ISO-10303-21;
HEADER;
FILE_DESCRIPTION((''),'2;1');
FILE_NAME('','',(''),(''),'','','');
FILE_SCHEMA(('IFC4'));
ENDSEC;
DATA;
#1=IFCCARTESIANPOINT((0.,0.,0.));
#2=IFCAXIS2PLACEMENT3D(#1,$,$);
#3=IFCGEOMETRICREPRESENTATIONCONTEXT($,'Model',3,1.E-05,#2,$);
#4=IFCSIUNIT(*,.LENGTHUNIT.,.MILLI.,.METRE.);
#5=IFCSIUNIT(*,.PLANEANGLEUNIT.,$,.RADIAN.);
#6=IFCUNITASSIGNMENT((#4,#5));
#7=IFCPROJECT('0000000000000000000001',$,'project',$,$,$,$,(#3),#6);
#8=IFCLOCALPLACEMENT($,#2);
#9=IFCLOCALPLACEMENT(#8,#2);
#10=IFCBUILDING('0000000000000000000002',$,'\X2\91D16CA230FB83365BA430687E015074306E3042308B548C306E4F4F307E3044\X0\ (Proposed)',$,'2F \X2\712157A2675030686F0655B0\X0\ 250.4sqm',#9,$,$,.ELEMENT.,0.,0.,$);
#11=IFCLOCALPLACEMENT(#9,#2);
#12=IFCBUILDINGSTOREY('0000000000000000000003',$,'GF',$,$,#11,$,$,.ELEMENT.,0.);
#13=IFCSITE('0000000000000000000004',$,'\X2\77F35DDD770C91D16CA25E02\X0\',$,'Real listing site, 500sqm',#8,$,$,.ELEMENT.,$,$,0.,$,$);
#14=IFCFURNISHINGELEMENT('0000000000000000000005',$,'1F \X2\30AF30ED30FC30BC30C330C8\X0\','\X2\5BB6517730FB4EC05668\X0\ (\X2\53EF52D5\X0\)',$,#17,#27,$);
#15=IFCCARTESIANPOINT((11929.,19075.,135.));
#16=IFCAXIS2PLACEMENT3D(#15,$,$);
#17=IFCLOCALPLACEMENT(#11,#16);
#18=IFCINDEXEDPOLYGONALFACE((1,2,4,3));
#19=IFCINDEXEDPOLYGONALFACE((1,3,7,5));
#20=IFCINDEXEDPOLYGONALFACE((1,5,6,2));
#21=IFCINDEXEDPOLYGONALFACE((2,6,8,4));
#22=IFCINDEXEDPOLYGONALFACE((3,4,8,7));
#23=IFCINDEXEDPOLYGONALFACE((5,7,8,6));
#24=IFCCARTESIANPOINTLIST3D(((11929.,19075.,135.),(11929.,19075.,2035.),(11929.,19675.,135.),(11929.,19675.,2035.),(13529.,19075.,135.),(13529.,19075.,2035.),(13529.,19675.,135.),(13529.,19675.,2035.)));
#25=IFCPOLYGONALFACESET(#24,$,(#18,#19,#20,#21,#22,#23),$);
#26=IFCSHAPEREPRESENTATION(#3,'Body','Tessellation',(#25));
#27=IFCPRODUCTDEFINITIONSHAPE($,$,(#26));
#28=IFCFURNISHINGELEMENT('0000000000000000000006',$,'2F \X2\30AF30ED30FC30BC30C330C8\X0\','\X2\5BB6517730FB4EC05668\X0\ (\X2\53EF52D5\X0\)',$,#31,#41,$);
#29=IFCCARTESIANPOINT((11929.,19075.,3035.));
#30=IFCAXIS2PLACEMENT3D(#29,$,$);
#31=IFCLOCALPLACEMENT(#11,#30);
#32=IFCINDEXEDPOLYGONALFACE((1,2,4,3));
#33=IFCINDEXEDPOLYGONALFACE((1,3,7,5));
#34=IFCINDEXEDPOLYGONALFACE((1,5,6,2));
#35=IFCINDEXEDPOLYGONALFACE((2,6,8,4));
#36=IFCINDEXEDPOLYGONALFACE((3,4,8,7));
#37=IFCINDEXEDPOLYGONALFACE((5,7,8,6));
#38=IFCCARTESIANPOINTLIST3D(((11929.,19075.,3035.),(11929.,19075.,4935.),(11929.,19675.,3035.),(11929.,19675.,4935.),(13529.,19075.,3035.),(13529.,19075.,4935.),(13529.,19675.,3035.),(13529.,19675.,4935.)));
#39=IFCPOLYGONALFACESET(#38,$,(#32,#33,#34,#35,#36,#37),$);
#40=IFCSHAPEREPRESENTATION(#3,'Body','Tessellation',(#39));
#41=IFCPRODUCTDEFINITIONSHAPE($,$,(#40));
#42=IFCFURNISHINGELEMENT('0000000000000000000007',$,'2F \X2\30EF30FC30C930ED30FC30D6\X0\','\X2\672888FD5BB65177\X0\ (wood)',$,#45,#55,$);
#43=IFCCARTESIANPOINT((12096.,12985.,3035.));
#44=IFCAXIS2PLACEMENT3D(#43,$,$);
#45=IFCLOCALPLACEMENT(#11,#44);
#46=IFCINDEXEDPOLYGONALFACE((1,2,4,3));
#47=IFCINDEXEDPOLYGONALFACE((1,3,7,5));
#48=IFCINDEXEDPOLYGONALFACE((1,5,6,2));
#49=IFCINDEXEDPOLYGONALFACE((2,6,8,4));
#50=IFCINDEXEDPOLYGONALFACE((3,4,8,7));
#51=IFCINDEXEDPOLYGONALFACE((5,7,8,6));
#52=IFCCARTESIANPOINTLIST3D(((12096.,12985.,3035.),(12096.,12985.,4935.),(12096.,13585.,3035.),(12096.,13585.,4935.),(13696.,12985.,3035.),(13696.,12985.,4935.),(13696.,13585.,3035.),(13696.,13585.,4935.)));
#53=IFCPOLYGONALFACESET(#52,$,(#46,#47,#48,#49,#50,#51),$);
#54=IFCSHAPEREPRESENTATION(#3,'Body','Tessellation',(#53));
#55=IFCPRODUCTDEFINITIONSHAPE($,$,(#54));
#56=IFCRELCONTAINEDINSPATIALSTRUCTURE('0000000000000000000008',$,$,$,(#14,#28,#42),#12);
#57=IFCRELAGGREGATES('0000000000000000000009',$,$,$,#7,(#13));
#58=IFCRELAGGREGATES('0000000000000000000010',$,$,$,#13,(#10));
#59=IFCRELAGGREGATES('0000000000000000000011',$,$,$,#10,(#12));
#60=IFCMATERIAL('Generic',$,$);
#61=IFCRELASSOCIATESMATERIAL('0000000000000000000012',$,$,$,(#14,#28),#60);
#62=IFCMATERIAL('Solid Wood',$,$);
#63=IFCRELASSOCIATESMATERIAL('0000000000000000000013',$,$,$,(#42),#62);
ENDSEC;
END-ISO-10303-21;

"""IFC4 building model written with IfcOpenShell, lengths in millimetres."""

from ifc_helpers import new_model, si_unit, frame, frame_2d, origin, place, context, project, spatial, rectangle, extrude, material, element, save


model = new_model("IFC4")

# Units and contexts
model_context = context("Model", 3, precision=1e-05, world=origin())
ifc_project = project(units=[si_unit("LENGTHUNIT", "METRE", prefix="MILLI"), si_unit("PLANEANGLEUNIT", "RADIAN")], contexts=[model_context])

# Site, building, storey
site_placement = place(None, origin())
site = spatial("IfcSite", under=ifc_project, at=site_placement, Name="石川県金沢市", ObjectType="Real listing site, 500sqm", CompositionType="ELEMENT", RefElevation=0.0)
building_placement = place(site_placement, origin())
building = spatial("IfcBuilding", under=site, at=building_placement, Name="金沢・茶室と縁側のある和の住まい (Proposed)", ObjectType="2F 無垢材と漆喰 250.4sqm", CompositionType="ELEMENT", ElevationOfRefHeight=0.0, ElevationOfTerrain=0.0)
storey_placement = place(building_placement, origin())
storey = spatial("IfcBuildingStorey", under=building, at=storey_placement, Name="GF", CompositionType="ELEMENT", Elevation=0.0)

# Shared definitions
ifc_material_1 = material(Name="Solid Wood")

# Shared definitions
ifc_material_2 = material(Name="Generic")

# Furnishing elements
furnishing_1_placement = place(storey_placement, frame((11929.0, 19075.0, 135.0)))
element("IfcFurnishingElement", 1, at=furnishing_1_placement, inside=storey, material=ifc_material_2, Name="1F クローゼット", Description="家具・什器 (可動)", context=model_context, shape_type="SweptSolid", body=[
    extrude(rectangle(XDim=1600.0, YDim=600.0, at=frame_2d((800.0, 300.0))), frame((11929.0, 19075.0, 135.0)), (0.0, 0.0, 1.0), 1900.0),
])
furnishing_2_placement = place(storey_placement, frame((11929.0, 19075.0, 3035.0)))
element("IfcFurnishingElement", 2, at=furnishing_2_placement, inside=storey, material=ifc_material_2, Name="2F クローゼット", Description="家具・什器 (可動)", context=model_context, shape_type="SweptSolid", body=[
    extrude(rectangle(XDim=1600.0, YDim=600.0, at=frame_2d((800.0, 300.0))), frame((11929.0, 19075.0, 3035.0)), (0.0, 0.0, 1.0), 1900.0),
])
furnishing_3_placement = place(storey_placement, frame((12096.0, 12985.0, 3035.0)))
element("IfcFurnishingElement", 3, at=furnishing_3_placement, inside=storey, material=ifc_material_1, Name="2F ワードローブ", Description="木製家具 (wood)", context=model_context, shape_type="SweptSolid", body=[
    extrude(rectangle(XDim=1600.0, YDim=600.0, at=frame_2d((800.0, 300.0))), frame((12096.0, 12985.0, 3035.0)), (0.0, 0.0, 1.0), 1900.0),
])

save(model, "model.ifc")
